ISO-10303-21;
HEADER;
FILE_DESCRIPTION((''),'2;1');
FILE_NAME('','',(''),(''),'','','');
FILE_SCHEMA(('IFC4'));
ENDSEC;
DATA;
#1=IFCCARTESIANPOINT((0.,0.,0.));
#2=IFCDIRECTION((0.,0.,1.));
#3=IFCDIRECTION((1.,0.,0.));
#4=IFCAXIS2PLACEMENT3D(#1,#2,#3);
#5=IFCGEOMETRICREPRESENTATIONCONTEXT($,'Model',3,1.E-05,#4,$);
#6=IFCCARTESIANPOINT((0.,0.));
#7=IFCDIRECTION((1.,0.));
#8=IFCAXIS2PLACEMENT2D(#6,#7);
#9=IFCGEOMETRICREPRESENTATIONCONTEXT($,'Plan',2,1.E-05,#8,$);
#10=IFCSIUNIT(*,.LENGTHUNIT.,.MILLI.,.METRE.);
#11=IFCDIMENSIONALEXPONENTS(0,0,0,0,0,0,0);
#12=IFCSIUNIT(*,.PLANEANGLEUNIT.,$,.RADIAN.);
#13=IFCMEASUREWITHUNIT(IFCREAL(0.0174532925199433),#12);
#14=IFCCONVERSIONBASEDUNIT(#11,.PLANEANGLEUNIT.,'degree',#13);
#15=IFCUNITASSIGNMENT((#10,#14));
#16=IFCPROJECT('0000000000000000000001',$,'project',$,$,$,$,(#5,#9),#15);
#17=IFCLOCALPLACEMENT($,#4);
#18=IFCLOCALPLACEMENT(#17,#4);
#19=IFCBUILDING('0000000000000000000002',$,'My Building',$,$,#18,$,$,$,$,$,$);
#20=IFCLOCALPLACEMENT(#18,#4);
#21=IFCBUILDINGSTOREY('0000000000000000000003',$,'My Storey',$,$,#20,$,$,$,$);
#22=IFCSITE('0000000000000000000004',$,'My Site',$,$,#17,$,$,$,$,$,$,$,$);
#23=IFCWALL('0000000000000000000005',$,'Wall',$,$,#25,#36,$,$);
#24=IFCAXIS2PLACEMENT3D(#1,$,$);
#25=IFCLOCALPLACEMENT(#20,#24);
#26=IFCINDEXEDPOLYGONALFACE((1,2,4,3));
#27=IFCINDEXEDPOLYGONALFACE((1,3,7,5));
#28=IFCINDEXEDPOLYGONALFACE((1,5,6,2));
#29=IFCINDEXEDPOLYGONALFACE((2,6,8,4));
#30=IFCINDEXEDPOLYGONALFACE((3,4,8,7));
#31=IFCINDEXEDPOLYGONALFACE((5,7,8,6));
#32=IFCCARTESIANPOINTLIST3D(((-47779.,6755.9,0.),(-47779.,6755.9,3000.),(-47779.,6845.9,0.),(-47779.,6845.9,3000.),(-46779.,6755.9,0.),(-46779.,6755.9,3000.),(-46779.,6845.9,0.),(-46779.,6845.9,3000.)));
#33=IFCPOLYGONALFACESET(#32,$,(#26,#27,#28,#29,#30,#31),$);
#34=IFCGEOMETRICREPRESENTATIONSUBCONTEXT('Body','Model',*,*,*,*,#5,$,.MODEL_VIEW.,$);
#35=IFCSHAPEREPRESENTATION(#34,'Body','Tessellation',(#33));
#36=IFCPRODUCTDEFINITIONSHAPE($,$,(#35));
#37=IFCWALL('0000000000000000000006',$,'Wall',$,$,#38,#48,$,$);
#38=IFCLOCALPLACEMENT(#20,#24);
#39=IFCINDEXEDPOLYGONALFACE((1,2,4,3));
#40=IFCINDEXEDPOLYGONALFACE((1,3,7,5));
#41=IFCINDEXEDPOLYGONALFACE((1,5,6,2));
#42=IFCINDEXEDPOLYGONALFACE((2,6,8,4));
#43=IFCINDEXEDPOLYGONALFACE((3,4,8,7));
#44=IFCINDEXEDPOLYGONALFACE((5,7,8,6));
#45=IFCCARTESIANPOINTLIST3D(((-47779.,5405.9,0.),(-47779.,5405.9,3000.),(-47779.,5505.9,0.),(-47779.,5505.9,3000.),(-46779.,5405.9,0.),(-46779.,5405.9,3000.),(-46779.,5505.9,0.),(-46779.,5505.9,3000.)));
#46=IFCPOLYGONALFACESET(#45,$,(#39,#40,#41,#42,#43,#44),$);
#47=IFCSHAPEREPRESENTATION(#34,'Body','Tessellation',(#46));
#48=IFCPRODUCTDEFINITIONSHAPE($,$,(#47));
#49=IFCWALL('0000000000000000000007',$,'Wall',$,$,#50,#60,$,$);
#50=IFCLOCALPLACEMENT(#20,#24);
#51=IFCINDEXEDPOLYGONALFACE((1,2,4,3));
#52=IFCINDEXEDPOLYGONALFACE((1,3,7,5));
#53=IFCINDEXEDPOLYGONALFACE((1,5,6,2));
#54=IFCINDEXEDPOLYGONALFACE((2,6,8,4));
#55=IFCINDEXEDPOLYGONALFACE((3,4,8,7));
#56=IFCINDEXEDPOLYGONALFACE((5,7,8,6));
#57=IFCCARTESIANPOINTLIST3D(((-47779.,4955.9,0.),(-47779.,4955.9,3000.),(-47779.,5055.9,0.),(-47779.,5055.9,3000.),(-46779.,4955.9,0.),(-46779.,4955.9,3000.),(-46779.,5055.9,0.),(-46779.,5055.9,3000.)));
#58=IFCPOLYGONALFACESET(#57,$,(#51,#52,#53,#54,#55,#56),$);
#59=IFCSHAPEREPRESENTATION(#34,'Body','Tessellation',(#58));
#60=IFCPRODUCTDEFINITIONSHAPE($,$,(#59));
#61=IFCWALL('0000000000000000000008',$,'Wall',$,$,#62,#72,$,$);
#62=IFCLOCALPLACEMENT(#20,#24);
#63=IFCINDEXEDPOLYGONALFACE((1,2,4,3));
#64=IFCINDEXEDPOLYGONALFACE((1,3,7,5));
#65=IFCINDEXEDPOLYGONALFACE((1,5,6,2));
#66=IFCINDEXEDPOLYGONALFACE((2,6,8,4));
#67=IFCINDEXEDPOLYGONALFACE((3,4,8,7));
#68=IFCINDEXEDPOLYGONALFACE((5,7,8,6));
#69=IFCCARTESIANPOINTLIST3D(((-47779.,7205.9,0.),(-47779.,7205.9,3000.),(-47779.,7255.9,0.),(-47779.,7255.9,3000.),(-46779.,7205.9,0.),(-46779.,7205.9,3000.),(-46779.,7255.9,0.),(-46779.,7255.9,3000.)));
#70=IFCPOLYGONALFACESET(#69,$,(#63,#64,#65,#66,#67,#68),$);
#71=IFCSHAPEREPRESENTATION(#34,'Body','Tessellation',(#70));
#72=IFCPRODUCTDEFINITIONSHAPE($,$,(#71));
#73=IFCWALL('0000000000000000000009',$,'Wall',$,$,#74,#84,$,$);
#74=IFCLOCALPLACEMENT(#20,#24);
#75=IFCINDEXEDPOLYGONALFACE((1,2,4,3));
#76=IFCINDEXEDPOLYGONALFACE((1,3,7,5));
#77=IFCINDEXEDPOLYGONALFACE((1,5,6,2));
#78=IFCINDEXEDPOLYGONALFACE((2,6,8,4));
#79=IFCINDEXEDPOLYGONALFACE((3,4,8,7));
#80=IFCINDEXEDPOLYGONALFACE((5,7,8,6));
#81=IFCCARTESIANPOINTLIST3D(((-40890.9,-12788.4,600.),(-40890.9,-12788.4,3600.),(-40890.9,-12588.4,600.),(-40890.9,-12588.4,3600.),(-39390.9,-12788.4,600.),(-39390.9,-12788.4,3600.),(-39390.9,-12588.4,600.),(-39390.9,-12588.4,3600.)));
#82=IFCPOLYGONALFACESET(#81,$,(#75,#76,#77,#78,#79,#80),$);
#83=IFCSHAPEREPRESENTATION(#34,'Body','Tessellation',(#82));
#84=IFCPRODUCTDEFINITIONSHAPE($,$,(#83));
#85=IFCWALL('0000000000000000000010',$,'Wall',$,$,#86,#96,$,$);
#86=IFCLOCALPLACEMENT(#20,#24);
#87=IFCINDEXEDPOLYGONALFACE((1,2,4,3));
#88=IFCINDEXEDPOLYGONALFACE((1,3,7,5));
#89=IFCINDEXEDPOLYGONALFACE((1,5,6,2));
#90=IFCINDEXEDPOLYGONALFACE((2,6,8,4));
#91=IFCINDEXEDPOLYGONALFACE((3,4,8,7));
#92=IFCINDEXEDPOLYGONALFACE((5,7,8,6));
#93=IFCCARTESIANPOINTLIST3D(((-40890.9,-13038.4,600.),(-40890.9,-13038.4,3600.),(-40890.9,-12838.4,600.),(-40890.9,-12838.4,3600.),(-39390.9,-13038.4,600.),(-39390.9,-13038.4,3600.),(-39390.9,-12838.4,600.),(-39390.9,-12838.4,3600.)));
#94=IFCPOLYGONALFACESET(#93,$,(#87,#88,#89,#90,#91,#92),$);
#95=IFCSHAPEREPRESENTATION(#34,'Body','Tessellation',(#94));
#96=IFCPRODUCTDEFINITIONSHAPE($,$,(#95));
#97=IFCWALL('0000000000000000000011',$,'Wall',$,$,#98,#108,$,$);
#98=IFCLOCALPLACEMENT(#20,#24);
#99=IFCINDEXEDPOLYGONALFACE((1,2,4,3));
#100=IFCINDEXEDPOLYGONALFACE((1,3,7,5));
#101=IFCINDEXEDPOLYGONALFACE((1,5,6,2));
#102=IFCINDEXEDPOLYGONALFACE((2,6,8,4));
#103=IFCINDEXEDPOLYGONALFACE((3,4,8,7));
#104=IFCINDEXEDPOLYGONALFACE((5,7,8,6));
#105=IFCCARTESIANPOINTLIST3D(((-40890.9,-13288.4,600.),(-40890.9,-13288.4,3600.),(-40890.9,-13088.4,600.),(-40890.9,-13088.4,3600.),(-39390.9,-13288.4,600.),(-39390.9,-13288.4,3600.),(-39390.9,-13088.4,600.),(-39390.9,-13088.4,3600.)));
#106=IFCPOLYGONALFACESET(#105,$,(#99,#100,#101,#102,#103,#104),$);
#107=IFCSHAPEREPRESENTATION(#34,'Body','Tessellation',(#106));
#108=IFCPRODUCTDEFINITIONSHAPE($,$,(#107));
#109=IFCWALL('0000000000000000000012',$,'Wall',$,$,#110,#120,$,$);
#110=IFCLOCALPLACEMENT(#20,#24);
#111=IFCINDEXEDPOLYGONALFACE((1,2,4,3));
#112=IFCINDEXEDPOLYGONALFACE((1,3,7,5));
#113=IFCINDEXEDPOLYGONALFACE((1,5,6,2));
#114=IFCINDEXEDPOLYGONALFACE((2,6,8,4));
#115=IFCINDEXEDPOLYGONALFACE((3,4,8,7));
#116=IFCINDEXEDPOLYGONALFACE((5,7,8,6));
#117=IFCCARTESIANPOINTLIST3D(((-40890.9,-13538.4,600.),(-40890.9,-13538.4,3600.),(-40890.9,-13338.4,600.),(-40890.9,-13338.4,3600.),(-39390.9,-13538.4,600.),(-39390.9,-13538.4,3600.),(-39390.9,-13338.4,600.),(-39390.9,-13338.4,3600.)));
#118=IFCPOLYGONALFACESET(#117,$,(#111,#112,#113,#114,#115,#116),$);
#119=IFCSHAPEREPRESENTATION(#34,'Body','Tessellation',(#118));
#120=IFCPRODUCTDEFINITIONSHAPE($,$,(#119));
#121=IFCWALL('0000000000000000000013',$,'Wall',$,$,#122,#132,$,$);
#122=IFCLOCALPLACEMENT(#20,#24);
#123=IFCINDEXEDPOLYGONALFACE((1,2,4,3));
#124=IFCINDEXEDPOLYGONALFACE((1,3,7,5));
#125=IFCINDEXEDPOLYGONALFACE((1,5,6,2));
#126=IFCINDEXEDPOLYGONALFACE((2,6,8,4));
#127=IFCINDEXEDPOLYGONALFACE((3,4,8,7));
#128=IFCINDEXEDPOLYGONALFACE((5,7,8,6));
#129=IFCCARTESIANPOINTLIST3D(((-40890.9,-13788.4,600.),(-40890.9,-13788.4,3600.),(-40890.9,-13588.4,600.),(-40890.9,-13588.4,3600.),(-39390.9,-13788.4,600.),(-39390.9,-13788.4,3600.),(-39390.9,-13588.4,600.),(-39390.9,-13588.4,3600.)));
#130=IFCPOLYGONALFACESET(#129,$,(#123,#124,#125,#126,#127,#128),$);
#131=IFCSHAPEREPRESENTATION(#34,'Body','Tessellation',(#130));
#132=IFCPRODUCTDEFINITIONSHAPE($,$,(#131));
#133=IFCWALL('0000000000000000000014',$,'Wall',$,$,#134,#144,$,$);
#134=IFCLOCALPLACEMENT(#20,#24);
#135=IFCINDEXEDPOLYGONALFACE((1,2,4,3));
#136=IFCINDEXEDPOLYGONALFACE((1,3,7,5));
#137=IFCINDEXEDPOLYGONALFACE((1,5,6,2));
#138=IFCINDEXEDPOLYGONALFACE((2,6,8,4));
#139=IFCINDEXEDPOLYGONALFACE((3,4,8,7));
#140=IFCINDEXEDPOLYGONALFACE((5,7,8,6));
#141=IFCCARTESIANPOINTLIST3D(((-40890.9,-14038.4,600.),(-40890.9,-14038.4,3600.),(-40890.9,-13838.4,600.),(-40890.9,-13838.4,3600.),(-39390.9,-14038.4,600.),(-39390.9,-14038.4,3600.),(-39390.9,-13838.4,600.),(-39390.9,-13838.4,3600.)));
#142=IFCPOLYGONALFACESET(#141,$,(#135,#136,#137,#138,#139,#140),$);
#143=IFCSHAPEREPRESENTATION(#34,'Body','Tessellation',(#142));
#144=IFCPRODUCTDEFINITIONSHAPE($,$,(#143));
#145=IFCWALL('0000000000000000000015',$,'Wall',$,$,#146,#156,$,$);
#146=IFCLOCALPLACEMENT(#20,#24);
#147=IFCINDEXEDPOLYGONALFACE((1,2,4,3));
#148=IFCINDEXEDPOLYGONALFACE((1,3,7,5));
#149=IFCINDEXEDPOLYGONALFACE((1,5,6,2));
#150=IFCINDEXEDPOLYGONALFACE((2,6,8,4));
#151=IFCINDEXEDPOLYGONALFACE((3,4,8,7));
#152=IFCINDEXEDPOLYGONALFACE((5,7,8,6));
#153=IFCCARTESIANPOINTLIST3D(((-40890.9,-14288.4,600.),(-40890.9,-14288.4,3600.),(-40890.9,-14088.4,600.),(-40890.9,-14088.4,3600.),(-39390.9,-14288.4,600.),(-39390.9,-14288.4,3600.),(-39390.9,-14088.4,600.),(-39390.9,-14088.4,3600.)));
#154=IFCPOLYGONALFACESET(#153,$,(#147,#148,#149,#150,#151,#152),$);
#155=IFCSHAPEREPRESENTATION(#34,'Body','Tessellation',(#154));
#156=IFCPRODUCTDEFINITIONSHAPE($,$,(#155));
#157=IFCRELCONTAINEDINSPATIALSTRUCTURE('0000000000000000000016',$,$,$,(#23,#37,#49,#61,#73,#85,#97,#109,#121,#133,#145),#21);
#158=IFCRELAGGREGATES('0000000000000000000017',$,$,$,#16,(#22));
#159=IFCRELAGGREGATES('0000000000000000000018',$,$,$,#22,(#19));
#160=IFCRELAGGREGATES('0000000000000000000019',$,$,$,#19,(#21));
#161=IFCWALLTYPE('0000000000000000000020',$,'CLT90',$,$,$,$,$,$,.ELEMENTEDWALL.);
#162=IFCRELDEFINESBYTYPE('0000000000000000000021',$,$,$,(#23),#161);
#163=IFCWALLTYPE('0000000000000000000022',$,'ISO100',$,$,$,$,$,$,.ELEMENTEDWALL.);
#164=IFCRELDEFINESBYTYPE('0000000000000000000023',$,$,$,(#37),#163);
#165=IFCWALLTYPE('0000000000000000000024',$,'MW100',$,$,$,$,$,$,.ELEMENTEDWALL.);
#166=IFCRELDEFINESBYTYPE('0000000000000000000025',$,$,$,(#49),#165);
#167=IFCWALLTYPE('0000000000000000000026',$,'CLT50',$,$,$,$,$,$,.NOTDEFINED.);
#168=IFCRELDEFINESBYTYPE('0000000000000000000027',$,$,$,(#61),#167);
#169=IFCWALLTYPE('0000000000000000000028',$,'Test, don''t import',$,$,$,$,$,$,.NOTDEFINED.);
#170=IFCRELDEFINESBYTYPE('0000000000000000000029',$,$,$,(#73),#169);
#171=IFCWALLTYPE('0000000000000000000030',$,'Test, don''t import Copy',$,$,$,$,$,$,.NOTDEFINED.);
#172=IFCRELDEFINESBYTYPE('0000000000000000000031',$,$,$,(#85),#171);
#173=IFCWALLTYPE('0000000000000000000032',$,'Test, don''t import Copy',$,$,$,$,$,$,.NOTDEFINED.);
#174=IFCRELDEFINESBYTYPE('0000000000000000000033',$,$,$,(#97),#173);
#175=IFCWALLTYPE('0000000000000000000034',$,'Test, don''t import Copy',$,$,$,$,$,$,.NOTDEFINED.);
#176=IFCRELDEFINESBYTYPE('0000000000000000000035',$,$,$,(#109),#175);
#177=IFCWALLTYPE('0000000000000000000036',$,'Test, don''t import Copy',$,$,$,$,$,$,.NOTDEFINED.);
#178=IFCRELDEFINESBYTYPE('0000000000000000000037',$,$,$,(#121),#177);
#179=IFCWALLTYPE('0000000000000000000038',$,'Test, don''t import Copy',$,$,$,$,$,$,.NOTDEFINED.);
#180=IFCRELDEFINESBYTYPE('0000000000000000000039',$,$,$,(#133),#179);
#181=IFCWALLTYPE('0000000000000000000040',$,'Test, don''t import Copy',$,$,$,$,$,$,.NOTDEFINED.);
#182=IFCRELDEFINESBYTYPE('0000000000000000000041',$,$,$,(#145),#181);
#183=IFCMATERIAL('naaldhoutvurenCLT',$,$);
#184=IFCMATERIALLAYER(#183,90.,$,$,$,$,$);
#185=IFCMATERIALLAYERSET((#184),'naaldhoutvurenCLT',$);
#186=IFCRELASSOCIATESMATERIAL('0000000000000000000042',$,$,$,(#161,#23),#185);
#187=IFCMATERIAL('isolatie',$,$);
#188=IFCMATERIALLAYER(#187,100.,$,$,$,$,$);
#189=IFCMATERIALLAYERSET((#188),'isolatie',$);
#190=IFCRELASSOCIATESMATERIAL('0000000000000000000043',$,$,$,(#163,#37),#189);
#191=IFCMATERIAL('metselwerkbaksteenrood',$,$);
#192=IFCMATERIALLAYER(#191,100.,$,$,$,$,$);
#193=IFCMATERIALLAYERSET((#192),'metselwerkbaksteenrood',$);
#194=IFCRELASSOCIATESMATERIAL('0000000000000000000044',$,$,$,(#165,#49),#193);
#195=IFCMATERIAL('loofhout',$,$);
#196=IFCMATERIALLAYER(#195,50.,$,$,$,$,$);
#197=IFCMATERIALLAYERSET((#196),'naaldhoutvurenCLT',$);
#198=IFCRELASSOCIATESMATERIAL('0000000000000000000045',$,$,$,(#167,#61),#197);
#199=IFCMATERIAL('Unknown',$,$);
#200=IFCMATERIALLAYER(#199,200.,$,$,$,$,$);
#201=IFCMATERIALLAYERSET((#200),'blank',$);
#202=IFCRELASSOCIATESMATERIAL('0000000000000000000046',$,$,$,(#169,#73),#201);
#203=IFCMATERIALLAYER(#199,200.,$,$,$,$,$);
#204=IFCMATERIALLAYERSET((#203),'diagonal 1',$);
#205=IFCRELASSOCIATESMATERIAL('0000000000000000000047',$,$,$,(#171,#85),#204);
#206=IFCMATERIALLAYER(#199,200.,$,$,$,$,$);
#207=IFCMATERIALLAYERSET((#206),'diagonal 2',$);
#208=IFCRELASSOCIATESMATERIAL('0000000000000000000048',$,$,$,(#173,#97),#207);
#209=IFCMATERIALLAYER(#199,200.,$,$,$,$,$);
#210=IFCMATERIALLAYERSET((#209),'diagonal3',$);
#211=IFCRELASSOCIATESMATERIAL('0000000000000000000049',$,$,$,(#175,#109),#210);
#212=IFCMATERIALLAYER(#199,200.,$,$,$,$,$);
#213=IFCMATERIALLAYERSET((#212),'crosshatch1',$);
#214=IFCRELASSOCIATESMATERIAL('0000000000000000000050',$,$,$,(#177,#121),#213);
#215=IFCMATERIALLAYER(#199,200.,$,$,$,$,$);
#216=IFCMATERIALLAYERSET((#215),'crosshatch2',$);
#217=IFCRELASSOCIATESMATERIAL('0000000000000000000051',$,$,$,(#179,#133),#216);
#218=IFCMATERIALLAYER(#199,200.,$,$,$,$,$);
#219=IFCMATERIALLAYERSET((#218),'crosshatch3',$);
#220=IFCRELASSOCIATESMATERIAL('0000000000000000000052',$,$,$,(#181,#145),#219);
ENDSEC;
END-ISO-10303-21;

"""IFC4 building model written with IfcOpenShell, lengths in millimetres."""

from ifc_helpers import new_model, entity, si_unit, converted_unit, frame, origin_with_axes, origin_2d_with_axis, place, context, subcontext, project, spatial, indexed_curve, outline, extrude, material, layer, layer_set, layer_usage, type_object, element, save


model = new_model("IFC4")

# Units and contexts
model_context = context("Model", 3, precision=1e-05, world=origin_with_axes())
plan_context = context("Plan", 2, precision=1e-05, world=origin_2d_with_axis())
body_context = subcontext(model_context, "Body", "Model", "MODEL_VIEW")
ifc_project = project(units=[si_unit("LENGTHUNIT", "METRE", prefix="MILLI"), converted_unit("PLANEANGLEUNIT", "degree", entity("IfcReal", 0.0174532925199433), si_unit("PLANEANGLEUNIT", "RADIAN"), dimensions=[0, 0, 0, 0, 0, 0, 0])], contexts=[model_context, plan_context])

# Site, building, storey
site_placement = place(None, origin_with_axes())
site = spatial("IfcSite", under=ifc_project, at=site_placement, Name="My Site")
building_placement = place(site_placement, origin_with_axes())
building = spatial("IfcBuilding", under=site, at=building_placement, Name="My Building")
storey_placement = place(building_placement, origin_with_axes())
storey = spatial("IfcBuildingStorey", under=building, at=storey_placement, Name="My Storey")

# Shared definitions
ifc_material_1 = material(Name="naaldhoutvurenCLT")

# Shared definitions
ifc_material_2 = material(Name="loofhout")

# Shared definitions
ifc_material_3 = material(Name="isolatie")

# Walls
ifc_layer_1 = layer(ifc_material_1, 90.0)
ifc_layer_set_1 = layer_set([ifc_layer_1], Name="naaldhoutvurenCLT")
ifc_layer_usage_1 = layer_usage(ifc_layer_set_1, "AXIS2", "POSITIVE", 0.0)
wall_type_1 = type_object("IfcWallType", Name="CLT90", PredefinedType="ELEMENTEDWALL", material=ifc_layer_set_1)
wall_1_placement = place(storey_placement, frame((-47779.0, 6755.9, 0.0), z_axis=(0.0, 0.0, 1.0), x_axis=(1.0, 0.0, 0.0)))
element("IfcWall", 1, at=wall_1_placement, inside=storey, type_object=wall_type_1, material=ifc_layer_usage_1, Name="Wall", context=body_context, shape_type="SweptSolid", body=[
    extrude(outline(indexed_curve([(0.0, 0.0), (0.0, 90.0), (1000.0, 90.0), (1000.0, 0.0), (0.0, 0.0)], self_intersect=False)), origin_with_axes(), (0.0, 0.0, 1.0), 3000.0),
])
ifc_layer_2 = layer(ifc_material_3, 100.0)
ifc_layer_set_2 = layer_set([ifc_layer_2], Name="isolatie")
ifc_layer_usage_2 = layer_usage(ifc_layer_set_2, "AXIS2", "POSITIVE", 0.0)
wall_type_2 = type_object("IfcWallType", Name="ISO100", PredefinedType="ELEMENTEDWALL", material=ifc_layer_set_2)
wall_2_placement = place(storey_placement, frame((-47779.0, 5405.9, 0.0), z_axis=(0.0, 0.0, 1.0), x_axis=(1.0, 0.0, 0.0)))
element("IfcWall", 2, at=wall_2_placement, inside=storey, type_object=wall_type_2, material=ifc_layer_usage_2, Name="Wall", context=body_context, shape_type="SweptSolid", body=[
    extrude(outline(indexed_curve([(0.0, 0.0), (0.0, 100.0), (1000.0, 100.0), (1000.0, 0.0), (0.0, 0.0)], self_intersect=False)), origin_with_axes(), (0.0, 0.0, 1.0), 3000.0),
])
ifc_material_4 = material(Name="metselwerkbaksteenrood")
ifc_layer_3 = layer(ifc_material_4, 100.0)
ifc_layer_set_3 = layer_set([ifc_layer_3], Name="metselwerkbaksteenrood")
ifc_layer_usage_3 = layer_usage(ifc_layer_set_3, "AXIS2", "POSITIVE", 0.0)
wall_type_3 = type_object("IfcWallType", Name="MW100", PredefinedType="ELEMENTEDWALL", material=ifc_layer_set_3)
wall_3_placement = place(storey_placement, frame((-47779.0, 4955.9, 0.0), z_axis=(0.0, 0.0, 1.0), x_axis=(1.0, 0.0, 0.0)))
element("IfcWall", 3, at=wall_3_placement, inside=storey, type_object=wall_type_3, material=ifc_layer_usage_3, Name="Wall", context=body_context, shape_type="SweptSolid", body=[
    extrude(outline(indexed_curve([(0.0, 0.0), (0.0, 100.0), (1000.0, 100.0), (1000.0, 0.0), (0.0, 0.0)], self_intersect=False)), origin_with_axes(), (0.0, 0.0, 1.0), 3000.0),
])
ifc_layer_4 = layer(ifc_material_2, 50.0)
ifc_layer_set_4 = layer_set([ifc_layer_4], Name="naaldhoutvurenCLT")
ifc_layer_usage_4 = layer_usage(ifc_layer_set_4, "AXIS2", "POSITIVE", 0.0)
wall_type_4 = type_object("IfcWallType", Name="CLT50", PredefinedType="NOTDEFINED", material=ifc_layer_set_4)
wall_4_placement = place(storey_placement, frame((-47779.0, 7205.9, 0.0), z_axis=(0.0, 0.0, 1.0), x_axis=(1.0, 0.0, 0.0)))
element("IfcWall", 4, at=wall_4_placement, inside=storey, type_object=wall_type_4, material=ifc_layer_usage_4, Name="Wall", context=body_context, shape_type="SweptSolid", body=[
    extrude(outline(indexed_curve([(0.0, 0.0), (0.0, 50.0), (1000.0, 50.0), (1000.0, 0.0), (0.0, 0.0)], self_intersect=False)), origin_with_axes(), (0.0, 0.0, 1.0), 3000.0),
])
ifc_material_5 = material(Name="Unknown")
ifc_layer_5 = layer(ifc_material_5, 200.0)
ifc_layer_set_5 = layer_set([ifc_layer_5], Name="blank")
ifc_layer_usage_5 = layer_usage(ifc_layer_set_5, "AXIS2", "POSITIVE", 0.0)
wall_type_5 = type_object("IfcWallType", Name="Test, don't import", PredefinedType="NOTDEFINED", material=ifc_layer_set_5)
wall_5_placement = place(storey_placement, frame((-40890.9, -12788.4, 600.0), z_axis=(0.0, 0.0, 1.0), x_axis=(1.0, 0.0, 0.0)))
element("IfcWall", 5, at=wall_5_placement, inside=storey, type_object=wall_type_5, material=ifc_layer_usage_5, Name="Wall", context=body_context, shape_type="SweptSolid", body=[
    extrude(outline(indexed_curve([(0.0, 0.0), (0.0, 200.0), (1500.0, 200.0), (1500.0, 0.0), (0.0, 0.0)], self_intersect=False)), origin_with_axes(), (0.0, 0.0, 1.0), 3000.0),
])
ifc_layer_6 = layer(ifc_material_5, 200.0)
ifc_layer_set_6 = layer_set([ifc_layer_6], Name="diagonal 1")
ifc_layer_usage_6 = layer_usage(ifc_layer_set_6, "AXIS2", "POSITIVE", 0.0)
wall_type_6 = type_object("IfcWallType", Name="Test, don't import Copy", PredefinedType="NOTDEFINED", material=ifc_layer_set_6)
wall_6_placement = place(storey_placement, frame((-40890.9, -13038.4, 600.0), z_axis=(0.0, 0.0, 1.0), x_axis=(1.0, 0.0, 0.0)))
element("IfcWall", 6, at=wall_6_placement, inside=storey, type_object=wall_type_6, material=ifc_layer_usage_6, Name="Wall", context=body_context, shape_type="SweptSolid", body=[
    extrude(outline(indexed_curve([(0.0, 0.0), (0.0, 200.0), (1500.0, 200.0), (1500.0, 0.0), (0.0, 0.0)], self_intersect=False)), origin_with_axes(), (0.0, 0.0, 1.0), 3000.0),
])
ifc_layer_7 = layer(ifc_material_5, 200.0)
ifc_layer_set_7 = layer_set([ifc_layer_7], Name="diagonal 2")
ifc_layer_usage_7 = layer_usage(ifc_layer_set_7, "AXIS2", "POSITIVE", 0.0)
wall_type_7 = type_object("IfcWallType", Name="Test, don't import Copy", PredefinedType="NOTDEFINED", material=ifc_layer_set_7)
wall_7_placement = place(storey_placement, frame((-40890.9, -13288.4, 600.0), z_axis=(0.0, 0.0, 1.0), x_axis=(1.0, 0.0, 0.0)))
element("IfcWall", 7, at=wall_7_placement, inside=storey, type_object=wall_type_7, material=ifc_layer_usage_7, Name="Wall", context=body_context, shape_type="SweptSolid", body=[
    extrude(outline(indexed_curve([(0.0, 0.0), (0.0, 200.0), (1500.0, 200.0), (1500.0, 0.0), (0.0, 0.0)], self_intersect=False)), origin_with_axes(), (0.0, 0.0, 1.0), 3000.0),
])
ifc_layer_8 = layer(ifc_material_5, 200.0)
ifc_layer_set_8 = layer_set([ifc_layer_8], Name="diagonal3")
ifc_layer_usage_8 = layer_usage(ifc_layer_set_8, "AXIS2", "POSITIVE", 0.0)
wall_type_8 = type_object("IfcWallType", Name="Test, don't import Copy", PredefinedType="NOTDEFINED", material=ifc_layer_set_8)
wall_8_placement = place(storey_placement, frame((-40890.9, -13538.4, 600.0), z_axis=(0.0, 0.0, 1.0), x_axis=(1.0, 0.0, 0.0)))
element("IfcWall", 8, at=wall_8_placement, inside=storey, type_object=wall_type_8, material=ifc_layer_usage_8, Name="Wall", context=body_context, shape_type="SweptSolid", body=[
    extrude(outline(indexed_curve([(0.0, 0.0), (0.0, 200.0), (1500.0, 200.0), (1500.0, 0.0), (0.0, 0.0)], self_intersect=False)), origin_with_axes(), (0.0, 0.0, 1.0), 3000.0),
])
ifc_layer_9 = layer(ifc_material_5, 200.0)
ifc_layer_set_9 = layer_set([ifc_layer_9], Name="crosshatch1")
ifc_layer_usage_9 = layer_usage(ifc_layer_set_9, "AXIS2", "POSITIVE", 0.0)
wall_type_9 = type_object("IfcWallType", Name="Test, don't import Copy", PredefinedType="NOTDEFINED", material=ifc_layer_set_9)
wall_9_placement = place(storey_placement, frame((-40890.9, -13788.4, 600.0), z_axis=(0.0, 0.0, 1.0), x_axis=(1.0, 0.0, 0.0)))
element("IfcWall", 9, at=wall_9_placement, inside=storey, type_object=wall_type_9, material=ifc_layer_usage_9, Name="Wall", context=body_context, shape_type="SweptSolid", body=[
    extrude(outline(indexed_curve([(0.0, 0.0), (0.0, 200.0), (1500.0, 200.0), (1500.0, 0.0), (0.0, 0.0)], self_intersect=False)), origin_with_axes(), (0.0, 0.0, 1.0), 3000.0),
])
ifc_layer_10 = layer(ifc_material_5, 200.0)
ifc_layer_set_10 = layer_set([ifc_layer_10], Name="crosshatch2")
ifc_layer_usage_10 = layer_usage(ifc_layer_set_10, "AXIS2", "POSITIVE", 0.0)
wall_type_10 = type_object("IfcWallType", Name="Test, don't import Copy", PredefinedType="NOTDEFINED", material=ifc_layer_set_10)
wall_10_placement = place(storey_placement, frame((-40890.9, -14038.4, 600.0), z_axis=(0.0, 0.0, 1.0), x_axis=(1.0, 0.0, 0.0)))
element("IfcWall", 10, at=wall_10_placement, inside=storey, type_object=wall_type_10, material=ifc_layer_usage_10, Name="Wall", context=body_context, shape_type="SweptSolid", body=[
    extrude(outline(indexed_curve([(0.0, 0.0), (0.0, 200.0), (1500.0, 200.0), (1500.0, 0.0), (0.0, 0.0)], self_intersect=False)), origin_with_axes(), (0.0, 0.0, 1.0), 3000.0),
])
ifc_layer_11 = layer(ifc_material_5, 200.0)
ifc_layer_set_11 = layer_set([ifc_layer_11], Name="crosshatch3")
ifc_layer_usage_11 = layer_usage(ifc_layer_set_11, "AXIS2", "POSITIVE", 0.0)
wall_type_11 = type_object("IfcWallType", Name="Test, don't import Copy", PredefinedType="NOTDEFINED", material=ifc_layer_set_11)
wall_11_placement = place(storey_placement, frame((-40890.9, -14288.4, 600.0), z_axis=(0.0, 0.0, 1.0), x_axis=(1.0, 0.0, 0.0)))
element("IfcWall", 11, at=wall_11_placement, inside=storey, type_object=wall_type_11, material=ifc_layer_usage_11, Name="Wall", context=body_context, shape_type="SweptSolid", body=[
    extrude(outline(indexed_curve([(0.0, 0.0), (0.0, 200.0), (1500.0, 200.0), (1500.0, 0.0), (0.0, 0.0)], self_intersect=False)), origin_with_axes(), (0.0, 0.0, 1.0), 3000.0),
])

save(model, "model.ifc")
